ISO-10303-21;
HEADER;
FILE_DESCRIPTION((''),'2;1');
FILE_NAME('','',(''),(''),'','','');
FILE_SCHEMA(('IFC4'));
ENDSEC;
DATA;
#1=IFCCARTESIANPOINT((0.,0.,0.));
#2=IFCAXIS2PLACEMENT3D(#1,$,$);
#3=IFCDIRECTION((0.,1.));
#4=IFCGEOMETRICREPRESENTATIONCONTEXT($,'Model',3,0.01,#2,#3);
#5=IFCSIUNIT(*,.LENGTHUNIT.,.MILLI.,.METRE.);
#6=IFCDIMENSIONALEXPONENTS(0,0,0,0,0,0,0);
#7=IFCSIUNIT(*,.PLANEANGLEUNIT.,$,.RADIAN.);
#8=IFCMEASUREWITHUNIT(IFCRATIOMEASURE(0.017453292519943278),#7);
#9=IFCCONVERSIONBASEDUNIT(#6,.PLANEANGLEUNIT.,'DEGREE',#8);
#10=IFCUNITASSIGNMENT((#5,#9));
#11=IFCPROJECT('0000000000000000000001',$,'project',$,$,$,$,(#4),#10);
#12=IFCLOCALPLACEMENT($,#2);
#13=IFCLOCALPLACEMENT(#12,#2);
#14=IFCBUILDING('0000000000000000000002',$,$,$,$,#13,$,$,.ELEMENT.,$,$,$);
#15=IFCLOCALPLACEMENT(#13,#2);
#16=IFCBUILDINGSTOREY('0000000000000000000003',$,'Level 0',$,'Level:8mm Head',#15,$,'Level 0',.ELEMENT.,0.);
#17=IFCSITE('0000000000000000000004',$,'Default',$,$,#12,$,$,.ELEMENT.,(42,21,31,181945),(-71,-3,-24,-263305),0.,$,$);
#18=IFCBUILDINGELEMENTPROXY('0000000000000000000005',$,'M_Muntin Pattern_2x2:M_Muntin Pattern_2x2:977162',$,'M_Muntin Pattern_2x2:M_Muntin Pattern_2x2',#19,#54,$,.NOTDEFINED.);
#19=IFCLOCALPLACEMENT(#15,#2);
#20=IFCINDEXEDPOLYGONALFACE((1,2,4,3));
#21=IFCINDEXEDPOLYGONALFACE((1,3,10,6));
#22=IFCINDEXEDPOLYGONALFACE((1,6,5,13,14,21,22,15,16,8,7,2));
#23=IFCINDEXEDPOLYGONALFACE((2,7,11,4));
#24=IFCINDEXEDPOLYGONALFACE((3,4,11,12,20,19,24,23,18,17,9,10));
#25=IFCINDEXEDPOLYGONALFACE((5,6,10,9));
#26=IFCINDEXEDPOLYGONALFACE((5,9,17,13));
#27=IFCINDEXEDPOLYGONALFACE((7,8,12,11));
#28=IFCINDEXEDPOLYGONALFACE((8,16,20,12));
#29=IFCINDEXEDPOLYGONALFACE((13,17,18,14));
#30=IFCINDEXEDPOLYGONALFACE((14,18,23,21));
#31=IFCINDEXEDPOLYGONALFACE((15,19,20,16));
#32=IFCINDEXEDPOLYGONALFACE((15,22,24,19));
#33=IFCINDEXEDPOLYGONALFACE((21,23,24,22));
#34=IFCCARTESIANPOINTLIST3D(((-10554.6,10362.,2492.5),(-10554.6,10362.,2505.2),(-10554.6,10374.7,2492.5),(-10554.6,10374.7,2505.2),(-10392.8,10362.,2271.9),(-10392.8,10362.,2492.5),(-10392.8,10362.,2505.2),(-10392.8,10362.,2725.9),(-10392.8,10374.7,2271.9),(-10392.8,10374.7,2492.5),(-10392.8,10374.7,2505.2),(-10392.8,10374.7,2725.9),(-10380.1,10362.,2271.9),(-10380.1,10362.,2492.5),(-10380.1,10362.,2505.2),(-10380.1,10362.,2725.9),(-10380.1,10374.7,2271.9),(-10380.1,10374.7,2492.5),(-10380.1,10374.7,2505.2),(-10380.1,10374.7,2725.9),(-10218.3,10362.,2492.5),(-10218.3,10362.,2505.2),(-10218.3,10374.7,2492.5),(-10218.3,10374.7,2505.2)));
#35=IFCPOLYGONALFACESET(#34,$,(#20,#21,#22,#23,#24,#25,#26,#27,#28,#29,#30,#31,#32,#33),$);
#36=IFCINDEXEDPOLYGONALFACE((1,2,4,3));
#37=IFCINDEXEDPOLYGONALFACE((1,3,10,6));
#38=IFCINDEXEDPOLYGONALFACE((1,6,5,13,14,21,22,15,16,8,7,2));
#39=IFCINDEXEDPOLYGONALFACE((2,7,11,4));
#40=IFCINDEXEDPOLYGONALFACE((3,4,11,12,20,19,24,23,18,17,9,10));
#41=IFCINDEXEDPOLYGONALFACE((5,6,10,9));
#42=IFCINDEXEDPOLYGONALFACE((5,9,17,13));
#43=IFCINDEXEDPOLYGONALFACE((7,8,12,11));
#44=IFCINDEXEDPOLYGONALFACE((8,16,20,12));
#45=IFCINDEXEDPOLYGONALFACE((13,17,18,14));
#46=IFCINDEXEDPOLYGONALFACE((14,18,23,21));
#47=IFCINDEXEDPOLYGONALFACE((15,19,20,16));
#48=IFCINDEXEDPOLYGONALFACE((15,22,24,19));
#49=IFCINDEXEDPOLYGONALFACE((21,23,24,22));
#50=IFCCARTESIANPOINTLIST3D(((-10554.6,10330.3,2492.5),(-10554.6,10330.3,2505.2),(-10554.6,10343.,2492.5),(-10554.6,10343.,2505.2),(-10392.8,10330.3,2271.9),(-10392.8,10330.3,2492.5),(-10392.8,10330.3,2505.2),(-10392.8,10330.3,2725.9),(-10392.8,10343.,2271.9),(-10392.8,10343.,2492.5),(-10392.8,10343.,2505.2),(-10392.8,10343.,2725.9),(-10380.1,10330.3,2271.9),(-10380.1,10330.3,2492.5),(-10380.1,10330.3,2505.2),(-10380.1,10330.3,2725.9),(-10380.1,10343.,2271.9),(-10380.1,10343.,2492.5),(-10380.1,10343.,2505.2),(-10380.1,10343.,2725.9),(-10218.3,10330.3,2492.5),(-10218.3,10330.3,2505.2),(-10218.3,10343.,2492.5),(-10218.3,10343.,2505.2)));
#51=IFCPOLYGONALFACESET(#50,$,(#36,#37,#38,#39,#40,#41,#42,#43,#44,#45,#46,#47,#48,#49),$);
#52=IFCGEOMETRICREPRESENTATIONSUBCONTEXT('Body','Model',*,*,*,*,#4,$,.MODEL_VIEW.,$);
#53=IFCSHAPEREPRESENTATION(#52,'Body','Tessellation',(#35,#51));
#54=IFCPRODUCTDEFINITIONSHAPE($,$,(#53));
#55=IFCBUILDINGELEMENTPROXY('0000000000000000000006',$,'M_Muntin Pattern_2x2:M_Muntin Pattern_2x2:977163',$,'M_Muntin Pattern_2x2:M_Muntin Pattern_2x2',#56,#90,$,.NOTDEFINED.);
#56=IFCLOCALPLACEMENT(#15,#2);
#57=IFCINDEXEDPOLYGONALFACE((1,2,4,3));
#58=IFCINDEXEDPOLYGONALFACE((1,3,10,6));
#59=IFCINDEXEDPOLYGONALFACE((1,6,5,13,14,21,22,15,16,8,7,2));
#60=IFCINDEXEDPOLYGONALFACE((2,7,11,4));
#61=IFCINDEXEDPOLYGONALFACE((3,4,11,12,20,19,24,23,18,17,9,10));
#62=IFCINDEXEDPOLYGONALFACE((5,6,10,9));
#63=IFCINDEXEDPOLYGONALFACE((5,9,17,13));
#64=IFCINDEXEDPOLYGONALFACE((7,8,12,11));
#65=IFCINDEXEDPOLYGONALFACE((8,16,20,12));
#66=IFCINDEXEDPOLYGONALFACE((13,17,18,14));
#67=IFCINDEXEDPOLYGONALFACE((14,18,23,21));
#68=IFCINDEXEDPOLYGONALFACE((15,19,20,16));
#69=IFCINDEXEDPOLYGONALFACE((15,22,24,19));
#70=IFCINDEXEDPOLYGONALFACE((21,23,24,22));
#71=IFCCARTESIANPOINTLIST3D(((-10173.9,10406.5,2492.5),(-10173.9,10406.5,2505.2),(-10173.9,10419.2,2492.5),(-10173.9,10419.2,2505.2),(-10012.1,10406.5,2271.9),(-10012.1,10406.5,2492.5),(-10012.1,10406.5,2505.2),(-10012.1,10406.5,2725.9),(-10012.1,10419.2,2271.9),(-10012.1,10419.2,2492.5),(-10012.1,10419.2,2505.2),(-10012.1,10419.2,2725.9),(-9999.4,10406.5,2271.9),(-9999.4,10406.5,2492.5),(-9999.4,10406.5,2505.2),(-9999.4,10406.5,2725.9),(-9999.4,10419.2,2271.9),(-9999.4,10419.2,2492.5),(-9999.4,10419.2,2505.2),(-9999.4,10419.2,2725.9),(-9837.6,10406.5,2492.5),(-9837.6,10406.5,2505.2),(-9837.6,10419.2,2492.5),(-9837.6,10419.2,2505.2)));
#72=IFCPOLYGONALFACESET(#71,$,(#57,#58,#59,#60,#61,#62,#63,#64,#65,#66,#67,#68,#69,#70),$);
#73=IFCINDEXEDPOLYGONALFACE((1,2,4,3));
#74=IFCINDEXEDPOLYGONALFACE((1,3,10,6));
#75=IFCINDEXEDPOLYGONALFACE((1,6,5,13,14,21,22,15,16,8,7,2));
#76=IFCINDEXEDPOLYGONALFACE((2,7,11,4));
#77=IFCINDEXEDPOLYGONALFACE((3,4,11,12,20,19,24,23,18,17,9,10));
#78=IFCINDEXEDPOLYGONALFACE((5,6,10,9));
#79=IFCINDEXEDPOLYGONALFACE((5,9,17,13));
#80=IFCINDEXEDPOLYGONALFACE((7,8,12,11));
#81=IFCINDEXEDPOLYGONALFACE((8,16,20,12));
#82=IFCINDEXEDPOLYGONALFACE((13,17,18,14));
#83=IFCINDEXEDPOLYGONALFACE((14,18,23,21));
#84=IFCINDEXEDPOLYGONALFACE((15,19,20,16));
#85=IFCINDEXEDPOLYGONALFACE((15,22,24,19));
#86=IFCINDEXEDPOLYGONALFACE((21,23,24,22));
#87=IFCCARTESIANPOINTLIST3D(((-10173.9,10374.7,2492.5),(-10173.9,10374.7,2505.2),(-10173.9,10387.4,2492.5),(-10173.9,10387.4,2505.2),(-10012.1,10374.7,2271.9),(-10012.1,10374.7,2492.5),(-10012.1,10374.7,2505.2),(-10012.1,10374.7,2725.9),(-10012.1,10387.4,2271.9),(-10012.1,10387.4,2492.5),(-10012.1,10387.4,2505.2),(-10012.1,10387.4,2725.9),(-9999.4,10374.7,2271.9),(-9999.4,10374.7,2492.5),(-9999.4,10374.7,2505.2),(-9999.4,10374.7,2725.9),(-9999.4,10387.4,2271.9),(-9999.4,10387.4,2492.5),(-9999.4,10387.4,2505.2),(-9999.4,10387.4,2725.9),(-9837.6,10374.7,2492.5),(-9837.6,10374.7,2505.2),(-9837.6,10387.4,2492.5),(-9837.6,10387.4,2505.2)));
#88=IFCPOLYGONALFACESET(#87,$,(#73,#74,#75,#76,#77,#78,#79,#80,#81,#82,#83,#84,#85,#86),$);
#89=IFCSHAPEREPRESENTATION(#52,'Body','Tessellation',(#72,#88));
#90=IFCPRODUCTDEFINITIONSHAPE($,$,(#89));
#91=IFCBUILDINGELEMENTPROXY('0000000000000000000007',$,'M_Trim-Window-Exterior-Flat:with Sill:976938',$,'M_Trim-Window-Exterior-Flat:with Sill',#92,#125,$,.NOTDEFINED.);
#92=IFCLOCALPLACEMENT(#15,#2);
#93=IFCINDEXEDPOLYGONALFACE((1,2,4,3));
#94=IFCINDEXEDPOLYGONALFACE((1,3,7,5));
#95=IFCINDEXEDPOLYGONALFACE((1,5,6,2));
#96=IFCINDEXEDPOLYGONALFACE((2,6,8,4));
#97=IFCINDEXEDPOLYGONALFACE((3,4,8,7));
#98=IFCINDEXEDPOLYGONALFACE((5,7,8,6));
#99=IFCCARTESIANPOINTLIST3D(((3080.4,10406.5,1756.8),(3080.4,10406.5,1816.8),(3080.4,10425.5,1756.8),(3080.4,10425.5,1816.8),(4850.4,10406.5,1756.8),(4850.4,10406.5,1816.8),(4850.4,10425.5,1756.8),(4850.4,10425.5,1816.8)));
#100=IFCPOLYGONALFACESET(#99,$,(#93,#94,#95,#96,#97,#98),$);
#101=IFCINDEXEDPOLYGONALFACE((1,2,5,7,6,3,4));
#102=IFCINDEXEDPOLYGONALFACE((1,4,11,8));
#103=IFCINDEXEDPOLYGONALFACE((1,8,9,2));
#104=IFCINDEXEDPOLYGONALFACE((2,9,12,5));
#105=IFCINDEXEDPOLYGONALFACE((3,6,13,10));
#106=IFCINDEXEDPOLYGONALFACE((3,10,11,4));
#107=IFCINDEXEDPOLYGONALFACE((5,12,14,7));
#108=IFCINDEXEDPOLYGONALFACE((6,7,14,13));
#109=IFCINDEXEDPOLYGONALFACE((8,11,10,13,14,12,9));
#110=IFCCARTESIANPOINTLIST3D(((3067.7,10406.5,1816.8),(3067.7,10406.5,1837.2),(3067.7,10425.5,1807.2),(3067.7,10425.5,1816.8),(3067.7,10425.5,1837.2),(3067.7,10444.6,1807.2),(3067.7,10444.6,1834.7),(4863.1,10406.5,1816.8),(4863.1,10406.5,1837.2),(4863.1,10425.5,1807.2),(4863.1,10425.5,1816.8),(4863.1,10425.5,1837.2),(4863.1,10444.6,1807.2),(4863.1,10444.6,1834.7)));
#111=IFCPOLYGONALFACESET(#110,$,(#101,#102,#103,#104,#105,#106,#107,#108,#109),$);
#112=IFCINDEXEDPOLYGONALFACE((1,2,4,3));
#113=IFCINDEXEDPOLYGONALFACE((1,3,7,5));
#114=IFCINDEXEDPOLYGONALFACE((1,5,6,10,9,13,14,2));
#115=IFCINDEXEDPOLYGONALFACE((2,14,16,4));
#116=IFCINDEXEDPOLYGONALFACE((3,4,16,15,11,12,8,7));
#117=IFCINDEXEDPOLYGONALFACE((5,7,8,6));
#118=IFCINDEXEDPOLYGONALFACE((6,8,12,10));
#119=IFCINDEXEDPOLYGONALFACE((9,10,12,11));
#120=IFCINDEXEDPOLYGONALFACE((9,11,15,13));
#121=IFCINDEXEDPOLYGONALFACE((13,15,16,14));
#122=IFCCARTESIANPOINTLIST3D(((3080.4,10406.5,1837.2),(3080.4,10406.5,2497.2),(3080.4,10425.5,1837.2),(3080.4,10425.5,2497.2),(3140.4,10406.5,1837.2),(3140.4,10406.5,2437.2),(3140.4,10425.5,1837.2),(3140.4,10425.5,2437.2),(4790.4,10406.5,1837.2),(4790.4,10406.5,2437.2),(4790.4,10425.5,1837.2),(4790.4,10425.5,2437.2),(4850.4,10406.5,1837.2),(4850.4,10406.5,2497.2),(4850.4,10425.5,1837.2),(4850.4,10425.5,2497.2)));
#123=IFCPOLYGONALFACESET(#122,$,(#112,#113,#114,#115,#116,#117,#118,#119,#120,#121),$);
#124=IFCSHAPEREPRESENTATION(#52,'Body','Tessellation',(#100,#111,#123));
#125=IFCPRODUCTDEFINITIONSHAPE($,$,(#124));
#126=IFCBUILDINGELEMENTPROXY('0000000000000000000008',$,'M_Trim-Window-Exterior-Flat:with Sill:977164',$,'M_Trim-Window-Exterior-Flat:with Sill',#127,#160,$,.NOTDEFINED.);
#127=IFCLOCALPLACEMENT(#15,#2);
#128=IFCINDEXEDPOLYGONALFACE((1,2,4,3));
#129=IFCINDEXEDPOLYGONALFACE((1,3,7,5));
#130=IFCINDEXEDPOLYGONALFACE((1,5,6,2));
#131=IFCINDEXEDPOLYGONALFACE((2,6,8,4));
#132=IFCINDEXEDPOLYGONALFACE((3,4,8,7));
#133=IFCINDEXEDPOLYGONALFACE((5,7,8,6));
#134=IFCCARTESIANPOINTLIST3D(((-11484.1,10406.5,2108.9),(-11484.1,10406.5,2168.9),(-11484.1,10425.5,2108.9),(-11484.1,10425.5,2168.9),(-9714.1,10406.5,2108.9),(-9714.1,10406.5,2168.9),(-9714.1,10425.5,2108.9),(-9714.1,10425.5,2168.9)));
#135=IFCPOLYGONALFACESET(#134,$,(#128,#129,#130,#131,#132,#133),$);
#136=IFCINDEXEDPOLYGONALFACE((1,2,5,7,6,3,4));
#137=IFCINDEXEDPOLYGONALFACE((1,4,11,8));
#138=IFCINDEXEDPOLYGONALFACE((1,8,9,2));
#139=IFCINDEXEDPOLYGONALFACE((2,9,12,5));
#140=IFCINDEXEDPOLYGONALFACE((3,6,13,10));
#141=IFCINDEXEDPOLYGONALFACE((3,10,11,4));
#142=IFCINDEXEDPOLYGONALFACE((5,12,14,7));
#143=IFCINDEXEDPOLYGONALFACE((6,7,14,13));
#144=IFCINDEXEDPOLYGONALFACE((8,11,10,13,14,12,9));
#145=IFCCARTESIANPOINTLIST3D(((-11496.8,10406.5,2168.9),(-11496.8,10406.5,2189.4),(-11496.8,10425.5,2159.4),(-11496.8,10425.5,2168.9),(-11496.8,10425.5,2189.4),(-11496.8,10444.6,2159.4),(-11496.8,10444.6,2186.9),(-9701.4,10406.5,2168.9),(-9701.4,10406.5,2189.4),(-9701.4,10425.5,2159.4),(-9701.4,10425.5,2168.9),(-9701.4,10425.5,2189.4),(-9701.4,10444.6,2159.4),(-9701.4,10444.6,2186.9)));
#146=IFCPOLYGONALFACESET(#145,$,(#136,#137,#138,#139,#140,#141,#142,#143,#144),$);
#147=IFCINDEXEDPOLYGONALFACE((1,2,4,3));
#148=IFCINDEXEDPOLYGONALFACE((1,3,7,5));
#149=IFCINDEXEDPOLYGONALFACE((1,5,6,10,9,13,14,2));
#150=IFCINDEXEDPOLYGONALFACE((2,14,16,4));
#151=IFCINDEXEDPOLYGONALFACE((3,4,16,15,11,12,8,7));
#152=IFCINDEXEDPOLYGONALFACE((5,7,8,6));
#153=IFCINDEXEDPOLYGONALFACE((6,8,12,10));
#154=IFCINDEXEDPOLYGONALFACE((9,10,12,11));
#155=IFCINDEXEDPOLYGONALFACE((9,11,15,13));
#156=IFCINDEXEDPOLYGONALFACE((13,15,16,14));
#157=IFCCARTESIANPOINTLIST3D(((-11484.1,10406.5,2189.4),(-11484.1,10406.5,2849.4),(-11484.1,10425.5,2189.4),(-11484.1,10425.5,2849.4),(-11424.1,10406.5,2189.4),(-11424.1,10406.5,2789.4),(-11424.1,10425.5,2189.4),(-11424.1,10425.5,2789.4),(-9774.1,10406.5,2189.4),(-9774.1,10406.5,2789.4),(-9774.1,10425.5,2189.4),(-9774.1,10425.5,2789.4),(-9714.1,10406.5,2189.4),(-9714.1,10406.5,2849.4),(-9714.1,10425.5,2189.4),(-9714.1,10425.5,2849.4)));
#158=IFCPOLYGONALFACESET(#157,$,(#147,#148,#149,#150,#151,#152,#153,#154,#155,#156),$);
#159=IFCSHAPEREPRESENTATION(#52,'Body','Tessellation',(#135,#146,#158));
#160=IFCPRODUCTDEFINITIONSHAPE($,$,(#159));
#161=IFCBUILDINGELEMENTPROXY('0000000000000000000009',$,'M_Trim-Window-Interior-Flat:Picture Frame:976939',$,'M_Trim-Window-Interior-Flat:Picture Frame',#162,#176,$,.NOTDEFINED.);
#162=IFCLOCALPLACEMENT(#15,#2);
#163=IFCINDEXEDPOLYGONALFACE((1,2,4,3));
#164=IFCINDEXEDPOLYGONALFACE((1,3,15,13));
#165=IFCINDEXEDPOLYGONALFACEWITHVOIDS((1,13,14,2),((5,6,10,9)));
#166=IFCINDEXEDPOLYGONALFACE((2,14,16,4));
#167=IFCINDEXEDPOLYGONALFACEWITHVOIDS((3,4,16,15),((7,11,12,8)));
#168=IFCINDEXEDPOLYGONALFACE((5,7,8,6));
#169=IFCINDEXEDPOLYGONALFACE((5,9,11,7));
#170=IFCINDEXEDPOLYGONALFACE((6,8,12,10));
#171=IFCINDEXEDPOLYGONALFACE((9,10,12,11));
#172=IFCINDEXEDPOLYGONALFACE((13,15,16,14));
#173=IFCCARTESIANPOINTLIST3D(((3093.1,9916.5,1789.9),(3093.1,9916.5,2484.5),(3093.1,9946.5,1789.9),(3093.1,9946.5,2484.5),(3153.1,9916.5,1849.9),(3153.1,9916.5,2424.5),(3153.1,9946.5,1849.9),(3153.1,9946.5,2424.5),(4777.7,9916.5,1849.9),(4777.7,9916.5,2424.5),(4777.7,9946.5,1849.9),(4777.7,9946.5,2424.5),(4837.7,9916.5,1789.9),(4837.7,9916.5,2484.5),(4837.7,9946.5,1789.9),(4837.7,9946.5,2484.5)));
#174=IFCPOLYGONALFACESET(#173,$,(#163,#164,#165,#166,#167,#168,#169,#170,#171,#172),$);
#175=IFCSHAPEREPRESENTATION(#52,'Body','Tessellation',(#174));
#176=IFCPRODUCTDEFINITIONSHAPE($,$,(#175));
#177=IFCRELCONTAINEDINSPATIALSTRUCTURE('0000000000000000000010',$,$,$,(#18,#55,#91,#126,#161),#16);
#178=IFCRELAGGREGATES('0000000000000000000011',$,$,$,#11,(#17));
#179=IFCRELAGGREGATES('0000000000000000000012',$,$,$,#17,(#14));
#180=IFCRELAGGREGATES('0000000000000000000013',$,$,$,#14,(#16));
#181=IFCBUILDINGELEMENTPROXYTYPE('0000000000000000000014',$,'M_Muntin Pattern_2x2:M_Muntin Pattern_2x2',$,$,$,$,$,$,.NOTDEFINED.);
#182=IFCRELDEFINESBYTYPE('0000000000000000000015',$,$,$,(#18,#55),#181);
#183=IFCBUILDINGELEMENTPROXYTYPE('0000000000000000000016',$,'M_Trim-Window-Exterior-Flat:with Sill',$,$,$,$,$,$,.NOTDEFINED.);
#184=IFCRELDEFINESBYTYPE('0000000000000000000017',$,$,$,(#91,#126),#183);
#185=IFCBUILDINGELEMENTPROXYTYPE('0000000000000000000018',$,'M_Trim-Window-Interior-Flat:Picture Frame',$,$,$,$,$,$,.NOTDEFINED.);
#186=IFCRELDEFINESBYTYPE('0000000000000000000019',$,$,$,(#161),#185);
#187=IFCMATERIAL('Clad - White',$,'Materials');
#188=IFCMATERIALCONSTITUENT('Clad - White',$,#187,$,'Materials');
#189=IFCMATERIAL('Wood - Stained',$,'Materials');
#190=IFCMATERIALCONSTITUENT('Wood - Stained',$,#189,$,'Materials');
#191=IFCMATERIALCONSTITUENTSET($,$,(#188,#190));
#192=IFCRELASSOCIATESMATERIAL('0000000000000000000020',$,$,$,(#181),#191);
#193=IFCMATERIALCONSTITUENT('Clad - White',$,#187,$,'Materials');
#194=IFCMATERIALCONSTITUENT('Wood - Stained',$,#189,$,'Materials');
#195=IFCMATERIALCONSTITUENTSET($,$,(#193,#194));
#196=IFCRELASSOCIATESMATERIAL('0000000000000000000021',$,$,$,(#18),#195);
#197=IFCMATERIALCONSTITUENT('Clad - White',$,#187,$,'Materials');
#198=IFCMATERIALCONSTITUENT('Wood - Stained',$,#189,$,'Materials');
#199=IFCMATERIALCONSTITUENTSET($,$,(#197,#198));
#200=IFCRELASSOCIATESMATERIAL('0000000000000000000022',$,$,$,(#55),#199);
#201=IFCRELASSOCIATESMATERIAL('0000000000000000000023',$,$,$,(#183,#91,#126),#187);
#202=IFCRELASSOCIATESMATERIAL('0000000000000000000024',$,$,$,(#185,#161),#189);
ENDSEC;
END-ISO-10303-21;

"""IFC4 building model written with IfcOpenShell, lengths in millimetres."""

from ifc_helpers import new_model, entity, si_unit, converted_unit, direction, frame, frame_2d, origin, place, context, subcontext, project, spatial, polyline, rectangle, outline, extrude, source, transform, mapped, material, constituent, constituent_set, type_object, type_shapes, element, save


model = new_model("IFC4")

# Units and contexts
model_context = context("Model", 3, precision=0.01, world=origin(), true_north=direction((0.0, 1.0)))
body_context = subcontext(model_context, "Body", "Model", "MODEL_VIEW")
ifc_project = project(units=[si_unit("LENGTHUNIT", "METRE", prefix="MILLI"), converted_unit("PLANEANGLEUNIT", "DEGREE", entity("IfcRatioMeasure", 0.017453292519943278), si_unit("PLANEANGLEUNIT", "RADIAN"), dimensions=[0, 0, 0, 0, 0, 0, 0])], contexts=[model_context])

# Site, building, storey
site_placement = place(None, origin())
site = spatial("IfcSite", under=ifc_project, at=site_placement, Name="Default", CompositionType="ELEMENT", RefLatitude=(42, 21, 31, 181945), RefLongitude=(-71, -3, -24, -263305), RefElevation=0.0)
building_placement = place(site_placement, origin())
building = spatial("IfcBuilding", under=site, at=building_placement, CompositionType="ELEMENT")
storey_placement = place(building_placement, origin())
storey = spatial("IfcBuildingStorey", under=building, at=storey_placement, Name="Level 0", ObjectType="Level:8mm Head", LongName="Level 0", CompositionType="ELEMENT", Elevation=0.0)

# Building element proxies
ifc_material_1 = material(Name="Clad - White", Category="Materials")
ifc_material_2 = material(Name="Wood - Stained", Category="Materials")
ifc_constituent_1 = constituent(ifc_material_1, Name="Clad - White", Category="Materials")
ifc_constituent_2 = constituent(ifc_material_2, Name="Wood - Stained", Category="Materials")
ifc_constituent_set_1 = constituent_set(constituents=[ifc_constituent_1, ifc_constituent_2])
building_element_proxy_type_1 = type_object("IfcBuildingElementProxyType", Name="M_Muntin Pattern_2x2:M_Muntin Pattern_2x2", PredefinedType="NOTDEFINED", material=ifc_constituent_set_1)
shared_shape_1 = source(origin(), body_context, "Body", "SweptSolid", [
    extrude(outline(polyline([(6.4, -6.4), (227.0, -6.4), (227.0, 6.3), (6.4, 6.3), (6.4, 168.2), (-6.3, 168.2), (-6.3, 6.3), (-227.0, 6.3), (-227.0, -6.4), (-6.3, -6.4), (-6.3, -168.1), (6.4, -168.1), (6.4, -6.4)])), frame((0.0, 9.5, 227.0), z_axis=(0.0, 1.0, 0.0), x_axis=(0.0, 0.0, 1.0)), (0.0, 0.0, 1.0), 12.7),
    extrude(outline(polyline([(6.4, -6.4), (227.0, -6.4), (227.0, 6.3), (6.4, 6.3), (6.4, 168.2), (-6.3, 168.2), (-6.3, 6.3), (-227.0, 6.3), (-227.0, -6.4), (-6.3, -6.4), (-6.3, -168.1), (6.4, -168.1), (6.4, -6.4)])), frame((0.0, -22.2, 227.0), z_axis=(0.0, 1.0, 0.0), x_axis=(0.0, 0.0, 1.0)), (0.0, 0.0, 1.0), 12.7),
])
type_shapes(building_element_proxy_type_1, [shared_shape_1])
ifc_constituent_3 = constituent(ifc_material_1, Name="Clad - White", Category="Materials")
ifc_constituent_4 = constituent(ifc_material_2, Name="Wood - Stained", Category="Materials")
ifc_constituent_set_2 = constituent_set(constituents=[ifc_constituent_3, ifc_constituent_4])
proxy_1_placement = place(storey_placement, frame((-10386.5, 10352.5, 2271.9)))
element("IfcBuildingElementProxy", 1, at=proxy_1_placement, inside=storey, type_object=building_element_proxy_type_1, material=ifc_constituent_set_2, Name="M_Muntin Pattern_2x2:M_Muntin Pattern_2x2:977162", ObjectType="M_Muntin Pattern_2x2:M_Muntin Pattern_2x2", PredefinedType="NOTDEFINED", context=body_context, shape_type="MappedRepresentation", body=[
    mapped(shared_shape_1, transform((0.0, 0.0, 0.0), scale=1.0)),
])
ifc_constituent_5 = constituent(ifc_material_1, Name="Clad - White", Category="Materials")
ifc_constituent_6 = constituent(ifc_material_2, Name="Wood - Stained", Category="Materials")
ifc_constituent_set_3 = constituent_set(constituents=[ifc_constituent_5, ifc_constituent_6])
proxy_2_placement = place(storey_placement, frame((-10005.7, 10396.9, 2271.9)))
element("IfcBuildingElementProxy", 2, at=proxy_2_placement, inside=storey, type_object=building_element_proxy_type_1, material=ifc_constituent_set_3, Name="M_Muntin Pattern_2x2:M_Muntin Pattern_2x2:977163", ObjectType="M_Muntin Pattern_2x2:M_Muntin Pattern_2x2", PredefinedType="NOTDEFINED", context=body_context, shape_type="MappedRepresentation", body=[
    mapped(shared_shape_1, transform((0.0, 0.0, 0.0), scale=1.0)),
])
building_element_proxy_type_2 = type_object("IfcBuildingElementProxyType", Name="M_Trim-Window-Exterior-Flat:with Sill", PredefinedType="NOTDEFINED", material=ifc_material_1)
shared_shape_2 = source(origin(), body_context, "Body", "SweptSolid", [
    extrude(rectangle(XDim=1770.0, YDim=60.0, at=frame_2d((0.0, 0.0), x_axis=(1.0, 0.0))), frame((0.0, -650.4, 0.0), z_axis=(0.0, 0.0, 1.0), x_axis=(-1.0, 0.0, 0.0)), (0.0, 0.0, 1.0), 19.0),
    extrude(outline(polyline([(-19.0, -15.2), (0.0, -15.2), (0.0, -5.7), (19.0, -5.7), (19.0, 14.8), (0.0, 14.8), (-19.0, 12.3), (-19.0, -15.2)])), frame((-897.7, -614.8, 19.0), z_axis=(1.0, 0.0, 0.0), x_axis=(0.0, 0.0, -1.0)), (0.0, 0.0, 1.0), 1795.4),
    extrude(outline(polyline([(-345.0, -885.0), (315.0, -885.0), (315.0, -825.0), (-285.0, -825.0), (-285.0, 825.0), (315.0, 825.0), (315.0, 885.0), (-345.0, 885.0), (-345.0, -885.0)])), frame((0.0, -285.0, 0.0), z_axis=(0.0, 0.0, 1.0), x_axis=(0.0, -1.0, 0.0)), (0.0, 0.0, 1.0), 19.0),
])
type_shapes(building_element_proxy_type_2, [shared_shape_2])
for number, where, z_axis, x_axis, name in (
    (3, (3965.4, 10406.5, 2437.2), (0.0, 1.0, 0.0), (-1.0, 0.0, 0.0), "M_Trim-Window-Exterior-Flat:with Sill:976938"),
    (4, (-10599.1, 10406.5, 2789.4), (0.0, 1.0, 0.0), (-1.0, 0.0, 0.0), "M_Trim-Window-Exterior-Flat:with Sill:977164"),
):
    element("IfcBuildingElementProxy", number, at=place(storey_placement, frame(where, z_axis=z_axis, x_axis=x_axis)), inside=storey, type_object=building_element_proxy_type_2, material=ifc_material_1, Name=name, ObjectType="M_Trim-Window-Exterior-Flat:with Sill", PredefinedType="NOTDEFINED", context=body_context, shape_type="MappedRepresentation", body=[
        mapped(shared_shape_2, transform((0.0, 0.0, 0.0), scale=1.0)),
    ])
building_element_proxy_type_3 = type_object("IfcBuildingElementProxyType", Name="M_Trim-Window-Interior-Flat:Picture Frame", PredefinedType="NOTDEFINED", material=ifc_material_2)
shared_shape_3 = source(origin(), body_context, "Body", "SweptSolid", [
    extrude(outline(polyline([(-872.3, -347.3), (872.3, -347.3), (872.3, 347.3), (-872.3, 347.3), (-872.3, -347.3)]), holes=[polyline([(-812.3, -287.3), (-812.3, 287.3), (812.3, 287.3), (812.3, -287.3), (-812.3, -287.3)])]), frame((0.0, -300.0, 0.0), z_axis=(0.0, 0.0, 1.0), x_axis=(-1.0, 0.0, 0.0)), (0.0, 0.0, 1.0), 30.0),
])
type_shapes(building_element_proxy_type_3, [shared_shape_3])
for number, where, z_axis, x_axis, name in (
    (5, (3965.4, 9946.5, 2437.2), (0.0, -1.0, 0.0), (1.0, 0.0, 0.0), "M_Trim-Window-Interior-Flat:Picture Frame:976939"),
):
    element("IfcBuildingElementProxy", number, at=place(storey_placement, frame(where, z_axis=z_axis, x_axis=x_axis)), inside=storey, type_object=building_element_proxy_type_3, material=ifc_material_2, Name=name, ObjectType="M_Trim-Window-Interior-Flat:Picture Frame", PredefinedType="NOTDEFINED", context=body_context, shape_type="MappedRepresentation", body=[
        mapped(shared_shape_3, transform((0.0, 0.0, 0.0), scale=1.0)),
    ])

save(model, "model.ifc")
